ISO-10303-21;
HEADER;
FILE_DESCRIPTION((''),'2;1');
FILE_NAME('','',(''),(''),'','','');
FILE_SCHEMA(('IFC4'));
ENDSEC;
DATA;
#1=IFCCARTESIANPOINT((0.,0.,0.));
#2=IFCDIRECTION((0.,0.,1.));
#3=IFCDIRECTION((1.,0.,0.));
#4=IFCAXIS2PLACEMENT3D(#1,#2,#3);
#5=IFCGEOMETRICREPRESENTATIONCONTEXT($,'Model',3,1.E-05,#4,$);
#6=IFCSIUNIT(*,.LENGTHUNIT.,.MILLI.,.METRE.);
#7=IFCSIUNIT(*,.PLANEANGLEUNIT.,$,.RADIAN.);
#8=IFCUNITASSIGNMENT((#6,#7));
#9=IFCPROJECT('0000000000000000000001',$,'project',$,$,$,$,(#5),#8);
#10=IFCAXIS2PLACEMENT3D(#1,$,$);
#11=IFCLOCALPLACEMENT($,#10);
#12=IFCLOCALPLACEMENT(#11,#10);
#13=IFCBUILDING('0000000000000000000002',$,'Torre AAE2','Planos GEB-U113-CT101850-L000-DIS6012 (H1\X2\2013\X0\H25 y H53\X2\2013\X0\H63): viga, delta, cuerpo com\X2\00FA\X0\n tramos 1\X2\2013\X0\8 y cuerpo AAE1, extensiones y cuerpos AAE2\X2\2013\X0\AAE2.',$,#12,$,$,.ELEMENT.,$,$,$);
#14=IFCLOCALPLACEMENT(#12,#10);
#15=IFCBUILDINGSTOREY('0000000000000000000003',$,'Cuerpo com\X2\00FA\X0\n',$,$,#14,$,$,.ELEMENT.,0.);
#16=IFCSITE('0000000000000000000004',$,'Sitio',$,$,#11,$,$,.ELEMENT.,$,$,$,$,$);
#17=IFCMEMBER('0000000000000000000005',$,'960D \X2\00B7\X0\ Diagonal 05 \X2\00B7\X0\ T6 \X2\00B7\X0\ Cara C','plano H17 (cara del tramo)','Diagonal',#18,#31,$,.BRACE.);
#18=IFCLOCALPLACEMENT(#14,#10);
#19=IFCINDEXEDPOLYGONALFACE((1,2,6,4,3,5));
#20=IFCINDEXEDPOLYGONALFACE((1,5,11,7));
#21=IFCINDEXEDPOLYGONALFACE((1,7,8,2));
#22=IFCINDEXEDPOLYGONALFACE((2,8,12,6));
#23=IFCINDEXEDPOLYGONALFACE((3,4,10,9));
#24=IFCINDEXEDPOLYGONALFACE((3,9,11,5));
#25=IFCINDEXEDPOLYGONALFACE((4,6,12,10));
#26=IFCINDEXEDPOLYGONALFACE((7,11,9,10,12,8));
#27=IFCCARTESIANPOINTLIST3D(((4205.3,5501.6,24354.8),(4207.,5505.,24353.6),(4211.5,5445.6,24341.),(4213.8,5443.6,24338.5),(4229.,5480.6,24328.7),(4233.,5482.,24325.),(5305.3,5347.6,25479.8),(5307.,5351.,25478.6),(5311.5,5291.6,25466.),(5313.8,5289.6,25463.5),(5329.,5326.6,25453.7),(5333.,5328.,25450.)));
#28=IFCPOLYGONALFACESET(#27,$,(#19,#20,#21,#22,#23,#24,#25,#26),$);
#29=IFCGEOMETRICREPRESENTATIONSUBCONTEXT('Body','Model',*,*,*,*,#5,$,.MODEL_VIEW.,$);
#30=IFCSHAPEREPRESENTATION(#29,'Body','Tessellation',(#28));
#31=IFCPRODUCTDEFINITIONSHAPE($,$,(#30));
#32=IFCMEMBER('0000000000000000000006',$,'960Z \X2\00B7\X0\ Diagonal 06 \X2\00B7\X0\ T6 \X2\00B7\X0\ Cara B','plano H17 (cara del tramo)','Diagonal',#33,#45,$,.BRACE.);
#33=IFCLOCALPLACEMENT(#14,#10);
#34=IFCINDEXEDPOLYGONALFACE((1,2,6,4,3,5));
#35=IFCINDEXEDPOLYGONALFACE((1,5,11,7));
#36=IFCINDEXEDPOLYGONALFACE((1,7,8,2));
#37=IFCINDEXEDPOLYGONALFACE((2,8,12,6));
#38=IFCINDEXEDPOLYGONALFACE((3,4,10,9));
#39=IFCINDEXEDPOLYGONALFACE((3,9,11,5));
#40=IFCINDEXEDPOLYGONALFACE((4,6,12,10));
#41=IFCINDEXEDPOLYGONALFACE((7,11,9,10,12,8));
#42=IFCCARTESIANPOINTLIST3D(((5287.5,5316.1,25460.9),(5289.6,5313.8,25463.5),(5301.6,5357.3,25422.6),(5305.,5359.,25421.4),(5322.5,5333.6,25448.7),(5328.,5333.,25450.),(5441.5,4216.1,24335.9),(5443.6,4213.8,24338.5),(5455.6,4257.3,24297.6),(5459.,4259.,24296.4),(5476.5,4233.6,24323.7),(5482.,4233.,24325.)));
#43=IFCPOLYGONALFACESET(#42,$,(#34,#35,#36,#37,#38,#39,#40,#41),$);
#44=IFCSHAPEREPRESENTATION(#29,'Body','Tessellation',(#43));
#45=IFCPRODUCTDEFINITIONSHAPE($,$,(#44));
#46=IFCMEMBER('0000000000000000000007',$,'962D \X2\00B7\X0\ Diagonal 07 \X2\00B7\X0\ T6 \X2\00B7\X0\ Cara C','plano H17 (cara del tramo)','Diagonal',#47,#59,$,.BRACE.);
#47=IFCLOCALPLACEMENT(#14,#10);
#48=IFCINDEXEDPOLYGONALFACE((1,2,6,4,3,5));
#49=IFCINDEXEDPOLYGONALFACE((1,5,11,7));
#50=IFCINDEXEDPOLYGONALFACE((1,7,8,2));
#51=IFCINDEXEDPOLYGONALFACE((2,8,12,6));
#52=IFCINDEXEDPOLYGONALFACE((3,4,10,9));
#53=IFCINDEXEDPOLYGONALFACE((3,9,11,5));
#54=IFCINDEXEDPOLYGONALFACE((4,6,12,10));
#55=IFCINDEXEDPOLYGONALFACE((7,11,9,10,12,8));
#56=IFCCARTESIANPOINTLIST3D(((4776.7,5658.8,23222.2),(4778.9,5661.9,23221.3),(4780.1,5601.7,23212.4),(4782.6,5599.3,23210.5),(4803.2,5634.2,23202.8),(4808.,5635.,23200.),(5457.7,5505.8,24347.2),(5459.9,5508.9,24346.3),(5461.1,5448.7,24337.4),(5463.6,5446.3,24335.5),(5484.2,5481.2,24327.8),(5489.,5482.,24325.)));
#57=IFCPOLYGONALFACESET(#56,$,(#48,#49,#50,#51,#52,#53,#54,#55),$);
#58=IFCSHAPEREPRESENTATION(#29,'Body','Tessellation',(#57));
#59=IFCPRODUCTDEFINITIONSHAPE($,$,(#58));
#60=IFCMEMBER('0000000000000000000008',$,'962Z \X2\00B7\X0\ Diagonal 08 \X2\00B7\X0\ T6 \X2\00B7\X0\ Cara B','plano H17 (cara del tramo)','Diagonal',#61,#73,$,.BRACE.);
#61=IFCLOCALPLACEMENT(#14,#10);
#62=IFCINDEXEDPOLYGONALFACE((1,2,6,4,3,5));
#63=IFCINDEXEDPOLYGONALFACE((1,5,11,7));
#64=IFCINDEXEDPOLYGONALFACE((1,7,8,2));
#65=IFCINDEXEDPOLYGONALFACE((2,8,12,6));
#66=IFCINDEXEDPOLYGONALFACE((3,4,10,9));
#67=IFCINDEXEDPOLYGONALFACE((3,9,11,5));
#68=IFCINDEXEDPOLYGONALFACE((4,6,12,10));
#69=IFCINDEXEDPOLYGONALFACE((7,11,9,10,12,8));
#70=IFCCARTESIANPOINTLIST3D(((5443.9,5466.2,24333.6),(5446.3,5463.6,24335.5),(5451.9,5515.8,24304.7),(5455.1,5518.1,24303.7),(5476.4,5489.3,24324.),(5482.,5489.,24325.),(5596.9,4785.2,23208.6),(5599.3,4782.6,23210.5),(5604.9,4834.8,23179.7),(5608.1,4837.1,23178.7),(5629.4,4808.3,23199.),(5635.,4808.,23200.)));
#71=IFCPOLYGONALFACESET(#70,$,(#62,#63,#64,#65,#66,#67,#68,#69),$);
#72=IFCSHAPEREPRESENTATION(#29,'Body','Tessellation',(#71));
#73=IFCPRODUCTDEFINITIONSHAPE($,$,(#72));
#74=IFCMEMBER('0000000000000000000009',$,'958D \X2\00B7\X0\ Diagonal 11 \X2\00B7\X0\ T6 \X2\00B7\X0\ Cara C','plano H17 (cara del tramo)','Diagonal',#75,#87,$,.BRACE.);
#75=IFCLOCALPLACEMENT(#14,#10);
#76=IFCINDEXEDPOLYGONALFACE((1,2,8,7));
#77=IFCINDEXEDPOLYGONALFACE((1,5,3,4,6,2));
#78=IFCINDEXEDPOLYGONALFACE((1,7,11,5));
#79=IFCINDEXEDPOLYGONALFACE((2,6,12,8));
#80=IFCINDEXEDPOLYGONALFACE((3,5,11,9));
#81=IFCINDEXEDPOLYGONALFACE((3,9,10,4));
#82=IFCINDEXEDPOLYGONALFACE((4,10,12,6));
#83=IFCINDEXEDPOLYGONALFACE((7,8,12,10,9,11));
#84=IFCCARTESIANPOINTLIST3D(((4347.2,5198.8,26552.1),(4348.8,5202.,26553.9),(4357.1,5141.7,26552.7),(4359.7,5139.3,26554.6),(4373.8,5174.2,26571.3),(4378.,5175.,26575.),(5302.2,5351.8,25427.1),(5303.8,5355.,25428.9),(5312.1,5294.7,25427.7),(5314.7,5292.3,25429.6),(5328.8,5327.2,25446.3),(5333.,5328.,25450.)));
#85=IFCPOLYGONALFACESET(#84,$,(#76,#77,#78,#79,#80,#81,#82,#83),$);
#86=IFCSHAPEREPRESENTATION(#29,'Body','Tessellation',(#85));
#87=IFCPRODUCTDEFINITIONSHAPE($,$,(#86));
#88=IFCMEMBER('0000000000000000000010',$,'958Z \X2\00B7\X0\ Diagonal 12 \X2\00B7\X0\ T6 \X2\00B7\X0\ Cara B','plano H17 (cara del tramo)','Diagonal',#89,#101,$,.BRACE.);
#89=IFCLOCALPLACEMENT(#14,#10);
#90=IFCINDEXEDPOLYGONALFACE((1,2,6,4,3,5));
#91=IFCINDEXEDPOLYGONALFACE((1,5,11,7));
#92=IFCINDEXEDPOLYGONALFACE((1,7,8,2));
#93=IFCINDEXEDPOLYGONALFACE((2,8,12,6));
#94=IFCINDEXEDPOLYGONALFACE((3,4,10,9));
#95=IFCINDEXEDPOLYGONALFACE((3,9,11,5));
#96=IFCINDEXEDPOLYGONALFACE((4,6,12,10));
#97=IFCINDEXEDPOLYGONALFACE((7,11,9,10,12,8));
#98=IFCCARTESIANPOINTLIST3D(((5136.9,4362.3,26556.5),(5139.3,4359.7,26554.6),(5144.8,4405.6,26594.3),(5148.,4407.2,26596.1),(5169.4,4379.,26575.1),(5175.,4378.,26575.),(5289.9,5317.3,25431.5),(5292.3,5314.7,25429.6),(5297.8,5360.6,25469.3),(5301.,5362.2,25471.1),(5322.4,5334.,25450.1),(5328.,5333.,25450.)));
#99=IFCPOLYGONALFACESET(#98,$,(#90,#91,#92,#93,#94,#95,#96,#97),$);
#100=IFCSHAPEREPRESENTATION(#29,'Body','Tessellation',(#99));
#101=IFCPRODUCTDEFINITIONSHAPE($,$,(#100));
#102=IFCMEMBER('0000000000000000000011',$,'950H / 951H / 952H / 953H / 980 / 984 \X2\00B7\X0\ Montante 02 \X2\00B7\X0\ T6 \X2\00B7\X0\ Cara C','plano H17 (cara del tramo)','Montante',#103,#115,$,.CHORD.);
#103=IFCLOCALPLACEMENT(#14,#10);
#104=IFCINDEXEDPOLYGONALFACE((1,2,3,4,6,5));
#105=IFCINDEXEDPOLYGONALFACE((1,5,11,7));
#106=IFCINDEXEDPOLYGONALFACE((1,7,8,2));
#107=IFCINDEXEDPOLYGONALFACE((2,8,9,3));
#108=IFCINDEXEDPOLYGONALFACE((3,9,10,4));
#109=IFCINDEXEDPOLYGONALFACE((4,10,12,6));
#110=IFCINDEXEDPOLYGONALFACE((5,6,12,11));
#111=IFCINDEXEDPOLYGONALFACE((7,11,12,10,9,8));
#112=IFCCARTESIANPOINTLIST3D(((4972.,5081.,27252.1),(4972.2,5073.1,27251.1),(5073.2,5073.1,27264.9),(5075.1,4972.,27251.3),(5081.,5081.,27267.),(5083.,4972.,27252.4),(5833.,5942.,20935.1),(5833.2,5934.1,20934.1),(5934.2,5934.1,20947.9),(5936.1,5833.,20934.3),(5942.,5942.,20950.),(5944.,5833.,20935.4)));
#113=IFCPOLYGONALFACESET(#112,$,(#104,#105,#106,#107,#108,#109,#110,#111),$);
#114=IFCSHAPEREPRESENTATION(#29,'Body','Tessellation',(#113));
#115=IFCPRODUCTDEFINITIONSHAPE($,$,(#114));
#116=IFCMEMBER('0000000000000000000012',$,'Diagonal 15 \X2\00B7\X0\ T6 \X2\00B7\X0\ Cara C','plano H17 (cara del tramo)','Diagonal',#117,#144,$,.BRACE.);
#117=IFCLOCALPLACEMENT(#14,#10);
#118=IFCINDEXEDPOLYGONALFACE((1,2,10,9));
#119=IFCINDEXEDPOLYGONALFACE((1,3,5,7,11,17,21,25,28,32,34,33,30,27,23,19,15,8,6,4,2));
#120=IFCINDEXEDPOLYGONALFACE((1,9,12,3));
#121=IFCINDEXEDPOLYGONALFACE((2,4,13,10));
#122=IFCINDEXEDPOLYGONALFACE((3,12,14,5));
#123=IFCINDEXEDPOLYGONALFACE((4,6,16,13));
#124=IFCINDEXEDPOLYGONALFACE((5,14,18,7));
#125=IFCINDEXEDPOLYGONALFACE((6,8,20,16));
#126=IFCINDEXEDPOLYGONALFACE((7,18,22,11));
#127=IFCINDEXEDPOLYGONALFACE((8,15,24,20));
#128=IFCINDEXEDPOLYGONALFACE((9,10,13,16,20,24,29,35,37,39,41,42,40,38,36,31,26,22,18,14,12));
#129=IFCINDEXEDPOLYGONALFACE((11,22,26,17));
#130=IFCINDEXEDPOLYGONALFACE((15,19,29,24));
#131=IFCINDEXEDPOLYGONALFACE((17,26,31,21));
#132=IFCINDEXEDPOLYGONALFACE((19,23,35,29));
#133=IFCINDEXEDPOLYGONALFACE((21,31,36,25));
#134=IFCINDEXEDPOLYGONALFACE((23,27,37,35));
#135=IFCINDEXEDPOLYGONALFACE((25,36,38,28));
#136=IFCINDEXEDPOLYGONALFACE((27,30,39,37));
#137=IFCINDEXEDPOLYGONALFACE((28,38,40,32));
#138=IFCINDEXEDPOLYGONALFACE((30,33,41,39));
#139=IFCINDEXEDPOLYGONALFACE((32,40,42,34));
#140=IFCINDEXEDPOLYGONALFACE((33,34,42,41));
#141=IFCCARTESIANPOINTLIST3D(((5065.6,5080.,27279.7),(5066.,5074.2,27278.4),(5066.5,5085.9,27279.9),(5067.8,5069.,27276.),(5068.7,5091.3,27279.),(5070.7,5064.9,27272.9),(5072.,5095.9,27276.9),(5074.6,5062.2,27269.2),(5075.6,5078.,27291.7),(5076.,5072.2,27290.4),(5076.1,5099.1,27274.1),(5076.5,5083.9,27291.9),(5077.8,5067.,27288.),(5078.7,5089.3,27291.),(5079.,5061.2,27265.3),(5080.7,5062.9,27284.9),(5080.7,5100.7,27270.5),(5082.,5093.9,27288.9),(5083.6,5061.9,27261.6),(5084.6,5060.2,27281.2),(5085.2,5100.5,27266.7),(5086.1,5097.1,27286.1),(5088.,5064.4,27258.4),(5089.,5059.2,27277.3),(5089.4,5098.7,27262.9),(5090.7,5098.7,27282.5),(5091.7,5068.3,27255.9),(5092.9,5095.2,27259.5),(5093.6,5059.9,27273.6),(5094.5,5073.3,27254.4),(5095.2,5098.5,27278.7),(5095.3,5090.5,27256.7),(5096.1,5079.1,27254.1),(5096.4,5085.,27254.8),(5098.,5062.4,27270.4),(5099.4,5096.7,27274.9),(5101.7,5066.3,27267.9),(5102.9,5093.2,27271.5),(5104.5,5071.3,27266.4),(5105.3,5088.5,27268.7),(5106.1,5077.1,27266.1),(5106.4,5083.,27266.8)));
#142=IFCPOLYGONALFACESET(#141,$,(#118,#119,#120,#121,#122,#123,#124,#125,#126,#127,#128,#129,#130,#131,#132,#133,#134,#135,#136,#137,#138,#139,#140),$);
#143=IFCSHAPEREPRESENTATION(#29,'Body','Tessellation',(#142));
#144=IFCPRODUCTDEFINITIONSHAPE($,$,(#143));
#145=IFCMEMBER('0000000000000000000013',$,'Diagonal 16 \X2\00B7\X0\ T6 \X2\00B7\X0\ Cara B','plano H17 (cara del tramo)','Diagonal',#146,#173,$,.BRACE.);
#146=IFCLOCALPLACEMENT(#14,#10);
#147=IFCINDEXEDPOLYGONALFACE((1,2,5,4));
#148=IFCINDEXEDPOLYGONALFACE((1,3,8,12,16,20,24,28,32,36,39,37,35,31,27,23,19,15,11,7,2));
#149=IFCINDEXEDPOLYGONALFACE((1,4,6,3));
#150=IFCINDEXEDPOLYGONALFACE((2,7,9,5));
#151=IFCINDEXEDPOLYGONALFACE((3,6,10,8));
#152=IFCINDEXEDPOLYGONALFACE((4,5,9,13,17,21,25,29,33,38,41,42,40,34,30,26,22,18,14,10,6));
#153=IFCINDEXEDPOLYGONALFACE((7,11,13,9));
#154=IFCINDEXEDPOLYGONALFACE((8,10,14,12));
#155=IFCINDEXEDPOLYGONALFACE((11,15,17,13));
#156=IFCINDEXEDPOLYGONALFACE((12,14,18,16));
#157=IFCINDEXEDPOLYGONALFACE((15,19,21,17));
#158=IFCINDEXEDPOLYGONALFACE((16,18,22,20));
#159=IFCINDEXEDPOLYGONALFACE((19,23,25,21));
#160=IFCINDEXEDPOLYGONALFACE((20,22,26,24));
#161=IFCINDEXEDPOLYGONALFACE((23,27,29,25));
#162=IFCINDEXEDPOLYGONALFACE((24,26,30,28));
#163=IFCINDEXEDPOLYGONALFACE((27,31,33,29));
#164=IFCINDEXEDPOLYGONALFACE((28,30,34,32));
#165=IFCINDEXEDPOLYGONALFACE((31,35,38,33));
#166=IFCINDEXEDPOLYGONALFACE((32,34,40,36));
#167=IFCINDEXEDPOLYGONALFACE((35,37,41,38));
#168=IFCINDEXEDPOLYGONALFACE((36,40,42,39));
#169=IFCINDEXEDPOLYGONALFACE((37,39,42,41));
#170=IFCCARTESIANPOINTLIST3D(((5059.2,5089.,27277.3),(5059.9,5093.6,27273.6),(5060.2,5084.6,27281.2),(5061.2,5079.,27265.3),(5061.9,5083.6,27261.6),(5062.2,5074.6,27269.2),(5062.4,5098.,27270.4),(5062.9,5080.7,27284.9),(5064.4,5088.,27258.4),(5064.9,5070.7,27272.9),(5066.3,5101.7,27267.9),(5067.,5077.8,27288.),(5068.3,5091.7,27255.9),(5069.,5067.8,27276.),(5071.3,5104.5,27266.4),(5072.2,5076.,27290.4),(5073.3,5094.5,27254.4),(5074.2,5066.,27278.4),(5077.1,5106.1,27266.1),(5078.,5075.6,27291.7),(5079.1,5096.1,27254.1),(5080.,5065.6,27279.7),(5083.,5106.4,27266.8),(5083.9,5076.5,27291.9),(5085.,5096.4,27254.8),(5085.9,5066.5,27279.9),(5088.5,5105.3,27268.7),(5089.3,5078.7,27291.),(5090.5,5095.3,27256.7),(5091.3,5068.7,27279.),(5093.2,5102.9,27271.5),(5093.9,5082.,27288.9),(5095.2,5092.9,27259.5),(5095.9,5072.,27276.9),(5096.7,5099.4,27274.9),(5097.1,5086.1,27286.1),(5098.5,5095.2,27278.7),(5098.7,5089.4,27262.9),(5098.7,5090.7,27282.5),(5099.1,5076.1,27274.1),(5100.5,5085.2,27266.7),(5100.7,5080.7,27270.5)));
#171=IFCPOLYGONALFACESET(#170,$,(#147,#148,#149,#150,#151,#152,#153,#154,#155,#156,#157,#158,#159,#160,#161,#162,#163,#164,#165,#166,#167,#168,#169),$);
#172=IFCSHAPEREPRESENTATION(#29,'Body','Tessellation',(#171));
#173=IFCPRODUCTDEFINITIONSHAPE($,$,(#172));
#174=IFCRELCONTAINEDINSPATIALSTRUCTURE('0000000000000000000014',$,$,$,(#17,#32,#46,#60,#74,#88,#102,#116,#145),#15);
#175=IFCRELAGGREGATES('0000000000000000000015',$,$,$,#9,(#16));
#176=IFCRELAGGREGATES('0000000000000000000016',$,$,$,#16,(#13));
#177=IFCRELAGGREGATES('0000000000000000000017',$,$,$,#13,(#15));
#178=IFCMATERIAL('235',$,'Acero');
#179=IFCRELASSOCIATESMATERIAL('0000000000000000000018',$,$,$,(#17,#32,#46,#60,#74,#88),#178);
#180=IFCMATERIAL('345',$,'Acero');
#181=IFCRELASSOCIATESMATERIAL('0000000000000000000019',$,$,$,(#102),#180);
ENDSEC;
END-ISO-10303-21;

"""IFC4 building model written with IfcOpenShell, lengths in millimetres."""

from ifc_helpers import new_model, si_unit, frame, frame_2d, origin, origin_with_axes, place, context, subcontext, project, spatial, circle, l_section, extrude, material, element, save


model = new_model("IFC4")

# Units and contexts
model_context = context("Model", 3, precision=1e-05, world=origin_with_axes())
body_context = subcontext(model_context, "Body", "Model", "MODEL_VIEW")
ifc_project = project(units=[si_unit("LENGTHUNIT", "METRE", prefix="MILLI"), si_unit("PLANEANGLEUNIT", "RADIAN")], contexts=[model_context])

# Site, building, storey
site_placement = place(None, origin())
site = spatial("IfcSite", under=ifc_project, at=site_placement, Name="Sitio", CompositionType="ELEMENT")
building_placement = place(site_placement, origin())
building = spatial("IfcBuilding", under=site, at=building_placement, Name="Torre AAE2", Description="Planos GEB-U113-CT101850-L000-DIS6012 (H1–H25 y H53–H63): viga, delta, cuerpo común tramos 1–8 y cuerpo AAE1, extensiones y cuerpos AAE2–AAE2.", CompositionType="ELEMENT")
storey_placement = place(building_placement, origin())
storey = spatial("IfcBuildingStorey", under=building, at=storey_placement, Name="Cuerpo común", CompositionType="ELEMENT", Elevation=0.0)

# Members
ifc_material_1 = material(Name="235", Category="Acero")
for number, where, z_axis, x_axis, name in (
    (1, (5333.0, 5328.0, 25450.0), (-0.695793, 0.097411, -0.711606), (-0.426031, -0.853622, 0.299712), "960D · Diagonal 05 · T6 · Cara C"),
    (2, (5328.0, 5333.0, 25450.0), (0.097411, -0.695793, -0.711606), (-0.853622, -0.426031, 0.299712), "960Z · Diagonal 06 · T6 · Cara B"),
):
    element("IfcMember", number, at=place(storey_placement, frame(where, z_axis=z_axis, x_axis=x_axis)), inside=storey, material=ifc_material_1, Name=name, Description="plano H17 (cara del tramo)", ObjectType="Diagonal", PredefinedType="BRACE", context=body_context, shape_type="SweptSolid", body=[
        extrude(l_section(Depth=45.0, Width=45.0, Thickness=4.0, at=frame_2d((22.5, 22.5))), None, (0.0, 0.0, 1.0), 1580.9),
    ])
for number, where, z_axis, x_axis, name in (
    (3, (5489.0, 5482.0, 24325.0), (-0.514377, 0.115565, -0.849742), (-0.563456, -0.792522, 0.233295), "962D · Diagonal 07 · T6 · Cara C"),
    (4, (5482.0, 5489.0, 24325.0), (0.115565, -0.514377, -0.849742), (-0.792522, -0.563456, 0.233295), "962Z · Diagonal 08 · T6 · Cara B"),
):
    element("IfcMember", number, at=place(storey_placement, frame(where, z_axis=z_axis, x_axis=x_axis)), inside=storey, material=ifc_material_1, Name=name, Description="plano H17 (cara del tramo)", ObjectType="Diagonal", PredefinedType="BRACE", context=body_context, shape_type="SweptSolid", body=[
        extrude(l_section(Depth=45.0, Width=45.0, Thickness=4.0, at=frame_2d((22.5, 22.5))), None, (0.0, 0.0, 1.0), 1323.9),
    ])
for number, where, z_axis, x_axis, name in (
    (5, (4378.0, 5175.0, 26575.0), (0.643706, 0.103128, -0.758292), (-0.40631, -0.793627, -0.452845), "958D · Diagonal 11 · T6 · Cara C"),
    (6, (5175.0, 4378.0, 26575.0), (0.103128, 0.643706, -0.758292), (-0.793627, -0.40631, -0.452845), "958Z · Diagonal 12 · T6 · Cara B"),
):
    element("IfcMember", number, at=place(storey_placement, frame(where, z_axis=z_axis, x_axis=x_axis)), inside=storey, material=ifc_material_1, Name=name, Description="plano H17 (cara del tramo)", ObjectType="Diagonal", PredefinedType="BRACE", context=body_context, shape_type="SweptSolid", body=[
        extrude(l_section(Depth=45.0, Width=45.0, Thickness=4.0, at=frame_2d((22.5, 22.5))), None, (0.0, 0.0, 1.0), 1483.6),
    ])
ifc_material_2 = material(Name="345", Category="Acero")
member_1_placement = place(storey_placement, frame((5081.0, 5081.0, 27267.0), z_axis=(0.133835, 0.133835, -0.981925), x_axis=(0.018074, -0.991004, -0.132609)))
element("IfcMember", 7, at=member_1_placement, inside=storey, material=ifc_material_2, Name="950H / 951H / 952H / 953H / 980 / 984 · Montante 02 · T6 · Cara C", Description="plano H17 (cara del tramo)", ObjectType="Montante", PredefinedType="CHORD", context=body_context, shape_type="SweptSolid", body=[
    extrude(l_section(Depth=110.0, Width=110.0, Thickness=8.0, at=frame_2d((55.0, 55.0))), None, (0.0, 0.0, 1.0), 6433.3),
])
for number, where, z_axis, x_axis, name in (
    (8, (5091.0, 5079.0, 27279.0), (-0.635001, 0.127, -0.762001), (-0.513563, -0.806261, 0.293592), "Diagonal 15 · T6 · Cara C"),
    (9, (5079.0, 5091.0, 27279.0), (0.127, -0.635001, -0.762001), (-0.806261, -0.513563, 0.293592), "Diagonal 16 · T6 · Cara B"),
):
    element("IfcMember", number, at=place(storey_placement, frame(where, z_axis=z_axis, x_axis=x_axis)), inside=storey, Name=name, Description="plano H17 (cara del tramo)", ObjectType="Diagonal", PredefinedType="BRACE", context=body_context, shape_type="SweptSolid", body=[
        extrude(circle(Radius=20.0), None, (0.0, 0.0, 1.0), 15.7),
    ])

save(model, "model.ifc")
